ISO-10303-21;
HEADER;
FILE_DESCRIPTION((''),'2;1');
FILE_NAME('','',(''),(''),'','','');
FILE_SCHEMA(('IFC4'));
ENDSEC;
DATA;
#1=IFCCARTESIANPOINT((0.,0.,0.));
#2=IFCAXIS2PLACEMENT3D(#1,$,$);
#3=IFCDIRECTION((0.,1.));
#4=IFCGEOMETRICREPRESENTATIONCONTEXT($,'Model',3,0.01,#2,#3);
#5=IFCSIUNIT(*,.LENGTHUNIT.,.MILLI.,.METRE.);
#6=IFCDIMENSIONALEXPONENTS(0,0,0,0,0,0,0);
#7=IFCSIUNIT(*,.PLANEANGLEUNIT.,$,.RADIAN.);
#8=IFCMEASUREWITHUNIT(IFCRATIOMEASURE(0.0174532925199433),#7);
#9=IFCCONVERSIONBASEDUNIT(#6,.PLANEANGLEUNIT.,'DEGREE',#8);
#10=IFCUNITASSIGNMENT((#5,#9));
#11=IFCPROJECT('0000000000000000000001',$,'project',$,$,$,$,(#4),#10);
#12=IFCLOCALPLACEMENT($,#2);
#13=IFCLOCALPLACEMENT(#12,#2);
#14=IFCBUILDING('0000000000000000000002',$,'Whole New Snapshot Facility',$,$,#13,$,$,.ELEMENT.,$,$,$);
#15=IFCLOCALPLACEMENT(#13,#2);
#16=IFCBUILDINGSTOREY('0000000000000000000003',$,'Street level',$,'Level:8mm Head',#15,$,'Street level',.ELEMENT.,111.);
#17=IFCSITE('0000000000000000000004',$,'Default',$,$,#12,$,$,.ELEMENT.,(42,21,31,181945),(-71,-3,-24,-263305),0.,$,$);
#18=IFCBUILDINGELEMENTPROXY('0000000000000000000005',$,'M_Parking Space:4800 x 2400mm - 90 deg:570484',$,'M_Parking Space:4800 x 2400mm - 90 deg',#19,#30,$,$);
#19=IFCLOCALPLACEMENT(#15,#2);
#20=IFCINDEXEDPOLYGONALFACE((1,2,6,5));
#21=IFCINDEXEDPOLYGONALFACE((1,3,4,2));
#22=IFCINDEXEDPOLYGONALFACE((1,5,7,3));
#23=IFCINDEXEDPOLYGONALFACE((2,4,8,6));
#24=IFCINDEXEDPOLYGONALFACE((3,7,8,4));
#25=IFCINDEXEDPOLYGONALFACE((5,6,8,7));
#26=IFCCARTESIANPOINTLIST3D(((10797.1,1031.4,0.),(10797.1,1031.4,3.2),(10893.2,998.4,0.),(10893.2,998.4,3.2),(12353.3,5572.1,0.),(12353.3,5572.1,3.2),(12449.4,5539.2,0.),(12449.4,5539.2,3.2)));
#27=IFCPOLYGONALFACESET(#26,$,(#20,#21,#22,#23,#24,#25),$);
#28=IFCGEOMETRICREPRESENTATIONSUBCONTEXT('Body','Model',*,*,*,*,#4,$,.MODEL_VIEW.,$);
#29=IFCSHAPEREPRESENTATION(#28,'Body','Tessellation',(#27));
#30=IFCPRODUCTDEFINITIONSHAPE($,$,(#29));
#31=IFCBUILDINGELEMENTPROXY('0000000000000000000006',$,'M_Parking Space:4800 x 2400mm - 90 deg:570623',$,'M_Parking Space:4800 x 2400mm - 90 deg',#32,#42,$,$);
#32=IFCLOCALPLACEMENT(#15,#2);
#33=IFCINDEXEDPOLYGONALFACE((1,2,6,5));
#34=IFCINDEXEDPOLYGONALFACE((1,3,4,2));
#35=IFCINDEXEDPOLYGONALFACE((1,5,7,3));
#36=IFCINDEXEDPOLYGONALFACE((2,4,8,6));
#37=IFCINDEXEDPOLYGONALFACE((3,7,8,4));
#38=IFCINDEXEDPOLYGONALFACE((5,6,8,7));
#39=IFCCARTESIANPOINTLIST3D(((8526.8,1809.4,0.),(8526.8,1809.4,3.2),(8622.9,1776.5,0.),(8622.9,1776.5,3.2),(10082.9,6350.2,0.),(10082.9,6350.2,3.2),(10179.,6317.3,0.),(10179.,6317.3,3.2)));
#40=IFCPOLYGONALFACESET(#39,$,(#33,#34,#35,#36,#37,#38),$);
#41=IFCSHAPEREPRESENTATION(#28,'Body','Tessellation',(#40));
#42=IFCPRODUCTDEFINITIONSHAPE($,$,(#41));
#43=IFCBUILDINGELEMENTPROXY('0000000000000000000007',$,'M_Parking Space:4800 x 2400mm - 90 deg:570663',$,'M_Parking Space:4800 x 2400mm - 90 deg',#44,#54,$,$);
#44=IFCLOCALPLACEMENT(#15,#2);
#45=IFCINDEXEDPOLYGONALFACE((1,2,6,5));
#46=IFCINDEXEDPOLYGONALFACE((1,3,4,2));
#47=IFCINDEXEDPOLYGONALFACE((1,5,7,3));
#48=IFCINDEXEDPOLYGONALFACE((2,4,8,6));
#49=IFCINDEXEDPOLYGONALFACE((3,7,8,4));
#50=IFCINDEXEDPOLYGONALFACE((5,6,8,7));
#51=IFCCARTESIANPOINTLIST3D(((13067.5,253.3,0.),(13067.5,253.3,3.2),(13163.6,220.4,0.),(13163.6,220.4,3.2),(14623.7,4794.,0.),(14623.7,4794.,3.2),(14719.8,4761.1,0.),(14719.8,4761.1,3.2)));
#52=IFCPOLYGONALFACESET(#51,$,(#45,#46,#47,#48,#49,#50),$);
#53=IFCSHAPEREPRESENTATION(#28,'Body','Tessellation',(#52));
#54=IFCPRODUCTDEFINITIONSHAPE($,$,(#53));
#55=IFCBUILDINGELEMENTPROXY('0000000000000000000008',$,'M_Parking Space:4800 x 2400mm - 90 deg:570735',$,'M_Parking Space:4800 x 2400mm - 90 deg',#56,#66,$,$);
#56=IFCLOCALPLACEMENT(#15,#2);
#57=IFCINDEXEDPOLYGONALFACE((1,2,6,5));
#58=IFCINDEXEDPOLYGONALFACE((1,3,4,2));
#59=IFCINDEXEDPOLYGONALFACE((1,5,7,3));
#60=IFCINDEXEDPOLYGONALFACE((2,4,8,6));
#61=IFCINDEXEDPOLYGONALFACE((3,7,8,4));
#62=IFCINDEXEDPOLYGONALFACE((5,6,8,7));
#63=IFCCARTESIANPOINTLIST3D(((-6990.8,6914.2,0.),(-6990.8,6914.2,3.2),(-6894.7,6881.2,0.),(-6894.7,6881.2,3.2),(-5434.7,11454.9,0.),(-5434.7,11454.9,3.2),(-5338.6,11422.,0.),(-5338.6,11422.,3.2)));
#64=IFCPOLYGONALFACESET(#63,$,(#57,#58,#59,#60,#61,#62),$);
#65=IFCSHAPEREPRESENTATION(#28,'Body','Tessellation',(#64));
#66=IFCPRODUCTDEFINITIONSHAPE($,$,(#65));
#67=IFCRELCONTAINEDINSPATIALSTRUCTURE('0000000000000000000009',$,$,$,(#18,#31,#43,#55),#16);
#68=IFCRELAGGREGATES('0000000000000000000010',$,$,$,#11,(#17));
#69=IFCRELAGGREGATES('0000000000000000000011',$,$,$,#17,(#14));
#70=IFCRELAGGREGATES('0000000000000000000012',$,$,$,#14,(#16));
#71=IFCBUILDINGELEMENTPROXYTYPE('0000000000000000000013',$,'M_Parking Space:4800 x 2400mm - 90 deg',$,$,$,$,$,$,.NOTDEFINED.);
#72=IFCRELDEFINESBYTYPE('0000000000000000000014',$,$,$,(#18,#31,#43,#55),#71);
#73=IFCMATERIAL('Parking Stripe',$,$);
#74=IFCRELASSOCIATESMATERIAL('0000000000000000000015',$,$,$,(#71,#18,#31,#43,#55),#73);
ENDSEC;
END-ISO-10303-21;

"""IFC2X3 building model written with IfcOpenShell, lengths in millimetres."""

from ifc_helpers import new_model, entity, si_unit, converted_unit, direction, frame, origin, origin_2d_with_axis, place, context, subcontext, project, spatial, rectangle, extrude, source, transform, mapped, material, type_object, type_shapes, element, save


model = new_model("IFC2X3")

# Units and contexts
model_context = context("Model", 3, precision=0.01, world=origin(), true_north=direction((0.0, 1.0)))
body_context = subcontext(model_context, "Body", "Model", "MODEL_VIEW")
ifc_project = project(units=[si_unit("LENGTHUNIT", "METRE", prefix="MILLI"), converted_unit("PLANEANGLEUNIT", "DEGREE", entity("IfcRatioMeasure", 0.0174532925199433), si_unit("PLANEANGLEUNIT", "RADIAN"), dimensions=[0, 0, 0, 0, 0, 0, 0])], contexts=[model_context])

# Site, building, storey
site_placement = place(None, origin())
site = spatial("IfcSite", under=ifc_project, at=site_placement, Name="Default", CompositionType="ELEMENT", RefLatitude=(42, 21, 31, 181945), RefLongitude=(-71, -3, -24, -263305), RefElevation=0.0)
building_placement = place(site_placement, origin())
building = spatial("IfcBuilding", under=site, at=building_placement, Name="Whole New Snapshot Facility", CompositionType="ELEMENT")
storey_placement = place(building_placement, origin())
storey = spatial("IfcBuildingStorey", under=building, at=storey_placement, Name="Street level", ObjectType="Level:8mm Head", LongName="Street level", CompositionType="ELEMENT", Elevation=111.0)

# Building element proxies
ifc_material_1 = material(Name="Parking Stripe")
building_element_proxy_type = type_object("IfcBuildingElementProxyType", Name="M_Parking Space:4800 x 2400mm - 90 deg", PredefinedType="NOTDEFINED", material=ifc_material_1)
shared_shape_1 = source(origin(), body_context, "Body", "SweptSolid", [
    extrude(rectangle(XDim=101.6, YDim=4800.0, at=origin_2d_with_axis()), frame((0.0, 2400.0, 0.0)), (0.0, 0.0, 1.0), 3.2),
])
type_shapes(building_element_proxy_type, [shared_shape_1])
for number, where, z_axis, x_axis, name in (
    (1, (10845.2, 1014.9, 0.0), (0.0, 0.0, 1.0), (0.945989, -0.324198, 0.0), "M_Parking Space:4800 x 2400mm - 90 deg:570484"),
    (2, (8574.8, 1793.0, 0.0), (0.0, 0.0, 1.0), (0.945989, -0.324198, 0.0), "M_Parking Space:4800 x 2400mm - 90 deg:570623"),
    (3, (13115.6, 236.8, 0.0), (0.0, 0.0, 1.0), (0.945989, -0.324198, 0.0), "M_Parking Space:4800 x 2400mm - 90 deg:570663"),
    (4, (-6942.8, 6897.7, 0.0), (0.0, 0.0, 1.0), (0.945989, -0.324198, 0.0), "M_Parking Space:4800 x 2400mm - 90 deg:570735"),
):
    element("IfcBuildingElementProxy", number, at=place(storey_placement, frame(where, z_axis=z_axis, x_axis=x_axis)), inside=storey, type_object=building_element_proxy_type, material=ifc_material_1, Name=name, ObjectType="M_Parking Space:4800 x 2400mm - 90 deg", context=body_context, shape_type="MappedRepresentation", body=[
        mapped(shared_shape_1, transform((0.0, 0.0, 0.0), scale=1.0)),
    ])

save(model, "model.ifc")
